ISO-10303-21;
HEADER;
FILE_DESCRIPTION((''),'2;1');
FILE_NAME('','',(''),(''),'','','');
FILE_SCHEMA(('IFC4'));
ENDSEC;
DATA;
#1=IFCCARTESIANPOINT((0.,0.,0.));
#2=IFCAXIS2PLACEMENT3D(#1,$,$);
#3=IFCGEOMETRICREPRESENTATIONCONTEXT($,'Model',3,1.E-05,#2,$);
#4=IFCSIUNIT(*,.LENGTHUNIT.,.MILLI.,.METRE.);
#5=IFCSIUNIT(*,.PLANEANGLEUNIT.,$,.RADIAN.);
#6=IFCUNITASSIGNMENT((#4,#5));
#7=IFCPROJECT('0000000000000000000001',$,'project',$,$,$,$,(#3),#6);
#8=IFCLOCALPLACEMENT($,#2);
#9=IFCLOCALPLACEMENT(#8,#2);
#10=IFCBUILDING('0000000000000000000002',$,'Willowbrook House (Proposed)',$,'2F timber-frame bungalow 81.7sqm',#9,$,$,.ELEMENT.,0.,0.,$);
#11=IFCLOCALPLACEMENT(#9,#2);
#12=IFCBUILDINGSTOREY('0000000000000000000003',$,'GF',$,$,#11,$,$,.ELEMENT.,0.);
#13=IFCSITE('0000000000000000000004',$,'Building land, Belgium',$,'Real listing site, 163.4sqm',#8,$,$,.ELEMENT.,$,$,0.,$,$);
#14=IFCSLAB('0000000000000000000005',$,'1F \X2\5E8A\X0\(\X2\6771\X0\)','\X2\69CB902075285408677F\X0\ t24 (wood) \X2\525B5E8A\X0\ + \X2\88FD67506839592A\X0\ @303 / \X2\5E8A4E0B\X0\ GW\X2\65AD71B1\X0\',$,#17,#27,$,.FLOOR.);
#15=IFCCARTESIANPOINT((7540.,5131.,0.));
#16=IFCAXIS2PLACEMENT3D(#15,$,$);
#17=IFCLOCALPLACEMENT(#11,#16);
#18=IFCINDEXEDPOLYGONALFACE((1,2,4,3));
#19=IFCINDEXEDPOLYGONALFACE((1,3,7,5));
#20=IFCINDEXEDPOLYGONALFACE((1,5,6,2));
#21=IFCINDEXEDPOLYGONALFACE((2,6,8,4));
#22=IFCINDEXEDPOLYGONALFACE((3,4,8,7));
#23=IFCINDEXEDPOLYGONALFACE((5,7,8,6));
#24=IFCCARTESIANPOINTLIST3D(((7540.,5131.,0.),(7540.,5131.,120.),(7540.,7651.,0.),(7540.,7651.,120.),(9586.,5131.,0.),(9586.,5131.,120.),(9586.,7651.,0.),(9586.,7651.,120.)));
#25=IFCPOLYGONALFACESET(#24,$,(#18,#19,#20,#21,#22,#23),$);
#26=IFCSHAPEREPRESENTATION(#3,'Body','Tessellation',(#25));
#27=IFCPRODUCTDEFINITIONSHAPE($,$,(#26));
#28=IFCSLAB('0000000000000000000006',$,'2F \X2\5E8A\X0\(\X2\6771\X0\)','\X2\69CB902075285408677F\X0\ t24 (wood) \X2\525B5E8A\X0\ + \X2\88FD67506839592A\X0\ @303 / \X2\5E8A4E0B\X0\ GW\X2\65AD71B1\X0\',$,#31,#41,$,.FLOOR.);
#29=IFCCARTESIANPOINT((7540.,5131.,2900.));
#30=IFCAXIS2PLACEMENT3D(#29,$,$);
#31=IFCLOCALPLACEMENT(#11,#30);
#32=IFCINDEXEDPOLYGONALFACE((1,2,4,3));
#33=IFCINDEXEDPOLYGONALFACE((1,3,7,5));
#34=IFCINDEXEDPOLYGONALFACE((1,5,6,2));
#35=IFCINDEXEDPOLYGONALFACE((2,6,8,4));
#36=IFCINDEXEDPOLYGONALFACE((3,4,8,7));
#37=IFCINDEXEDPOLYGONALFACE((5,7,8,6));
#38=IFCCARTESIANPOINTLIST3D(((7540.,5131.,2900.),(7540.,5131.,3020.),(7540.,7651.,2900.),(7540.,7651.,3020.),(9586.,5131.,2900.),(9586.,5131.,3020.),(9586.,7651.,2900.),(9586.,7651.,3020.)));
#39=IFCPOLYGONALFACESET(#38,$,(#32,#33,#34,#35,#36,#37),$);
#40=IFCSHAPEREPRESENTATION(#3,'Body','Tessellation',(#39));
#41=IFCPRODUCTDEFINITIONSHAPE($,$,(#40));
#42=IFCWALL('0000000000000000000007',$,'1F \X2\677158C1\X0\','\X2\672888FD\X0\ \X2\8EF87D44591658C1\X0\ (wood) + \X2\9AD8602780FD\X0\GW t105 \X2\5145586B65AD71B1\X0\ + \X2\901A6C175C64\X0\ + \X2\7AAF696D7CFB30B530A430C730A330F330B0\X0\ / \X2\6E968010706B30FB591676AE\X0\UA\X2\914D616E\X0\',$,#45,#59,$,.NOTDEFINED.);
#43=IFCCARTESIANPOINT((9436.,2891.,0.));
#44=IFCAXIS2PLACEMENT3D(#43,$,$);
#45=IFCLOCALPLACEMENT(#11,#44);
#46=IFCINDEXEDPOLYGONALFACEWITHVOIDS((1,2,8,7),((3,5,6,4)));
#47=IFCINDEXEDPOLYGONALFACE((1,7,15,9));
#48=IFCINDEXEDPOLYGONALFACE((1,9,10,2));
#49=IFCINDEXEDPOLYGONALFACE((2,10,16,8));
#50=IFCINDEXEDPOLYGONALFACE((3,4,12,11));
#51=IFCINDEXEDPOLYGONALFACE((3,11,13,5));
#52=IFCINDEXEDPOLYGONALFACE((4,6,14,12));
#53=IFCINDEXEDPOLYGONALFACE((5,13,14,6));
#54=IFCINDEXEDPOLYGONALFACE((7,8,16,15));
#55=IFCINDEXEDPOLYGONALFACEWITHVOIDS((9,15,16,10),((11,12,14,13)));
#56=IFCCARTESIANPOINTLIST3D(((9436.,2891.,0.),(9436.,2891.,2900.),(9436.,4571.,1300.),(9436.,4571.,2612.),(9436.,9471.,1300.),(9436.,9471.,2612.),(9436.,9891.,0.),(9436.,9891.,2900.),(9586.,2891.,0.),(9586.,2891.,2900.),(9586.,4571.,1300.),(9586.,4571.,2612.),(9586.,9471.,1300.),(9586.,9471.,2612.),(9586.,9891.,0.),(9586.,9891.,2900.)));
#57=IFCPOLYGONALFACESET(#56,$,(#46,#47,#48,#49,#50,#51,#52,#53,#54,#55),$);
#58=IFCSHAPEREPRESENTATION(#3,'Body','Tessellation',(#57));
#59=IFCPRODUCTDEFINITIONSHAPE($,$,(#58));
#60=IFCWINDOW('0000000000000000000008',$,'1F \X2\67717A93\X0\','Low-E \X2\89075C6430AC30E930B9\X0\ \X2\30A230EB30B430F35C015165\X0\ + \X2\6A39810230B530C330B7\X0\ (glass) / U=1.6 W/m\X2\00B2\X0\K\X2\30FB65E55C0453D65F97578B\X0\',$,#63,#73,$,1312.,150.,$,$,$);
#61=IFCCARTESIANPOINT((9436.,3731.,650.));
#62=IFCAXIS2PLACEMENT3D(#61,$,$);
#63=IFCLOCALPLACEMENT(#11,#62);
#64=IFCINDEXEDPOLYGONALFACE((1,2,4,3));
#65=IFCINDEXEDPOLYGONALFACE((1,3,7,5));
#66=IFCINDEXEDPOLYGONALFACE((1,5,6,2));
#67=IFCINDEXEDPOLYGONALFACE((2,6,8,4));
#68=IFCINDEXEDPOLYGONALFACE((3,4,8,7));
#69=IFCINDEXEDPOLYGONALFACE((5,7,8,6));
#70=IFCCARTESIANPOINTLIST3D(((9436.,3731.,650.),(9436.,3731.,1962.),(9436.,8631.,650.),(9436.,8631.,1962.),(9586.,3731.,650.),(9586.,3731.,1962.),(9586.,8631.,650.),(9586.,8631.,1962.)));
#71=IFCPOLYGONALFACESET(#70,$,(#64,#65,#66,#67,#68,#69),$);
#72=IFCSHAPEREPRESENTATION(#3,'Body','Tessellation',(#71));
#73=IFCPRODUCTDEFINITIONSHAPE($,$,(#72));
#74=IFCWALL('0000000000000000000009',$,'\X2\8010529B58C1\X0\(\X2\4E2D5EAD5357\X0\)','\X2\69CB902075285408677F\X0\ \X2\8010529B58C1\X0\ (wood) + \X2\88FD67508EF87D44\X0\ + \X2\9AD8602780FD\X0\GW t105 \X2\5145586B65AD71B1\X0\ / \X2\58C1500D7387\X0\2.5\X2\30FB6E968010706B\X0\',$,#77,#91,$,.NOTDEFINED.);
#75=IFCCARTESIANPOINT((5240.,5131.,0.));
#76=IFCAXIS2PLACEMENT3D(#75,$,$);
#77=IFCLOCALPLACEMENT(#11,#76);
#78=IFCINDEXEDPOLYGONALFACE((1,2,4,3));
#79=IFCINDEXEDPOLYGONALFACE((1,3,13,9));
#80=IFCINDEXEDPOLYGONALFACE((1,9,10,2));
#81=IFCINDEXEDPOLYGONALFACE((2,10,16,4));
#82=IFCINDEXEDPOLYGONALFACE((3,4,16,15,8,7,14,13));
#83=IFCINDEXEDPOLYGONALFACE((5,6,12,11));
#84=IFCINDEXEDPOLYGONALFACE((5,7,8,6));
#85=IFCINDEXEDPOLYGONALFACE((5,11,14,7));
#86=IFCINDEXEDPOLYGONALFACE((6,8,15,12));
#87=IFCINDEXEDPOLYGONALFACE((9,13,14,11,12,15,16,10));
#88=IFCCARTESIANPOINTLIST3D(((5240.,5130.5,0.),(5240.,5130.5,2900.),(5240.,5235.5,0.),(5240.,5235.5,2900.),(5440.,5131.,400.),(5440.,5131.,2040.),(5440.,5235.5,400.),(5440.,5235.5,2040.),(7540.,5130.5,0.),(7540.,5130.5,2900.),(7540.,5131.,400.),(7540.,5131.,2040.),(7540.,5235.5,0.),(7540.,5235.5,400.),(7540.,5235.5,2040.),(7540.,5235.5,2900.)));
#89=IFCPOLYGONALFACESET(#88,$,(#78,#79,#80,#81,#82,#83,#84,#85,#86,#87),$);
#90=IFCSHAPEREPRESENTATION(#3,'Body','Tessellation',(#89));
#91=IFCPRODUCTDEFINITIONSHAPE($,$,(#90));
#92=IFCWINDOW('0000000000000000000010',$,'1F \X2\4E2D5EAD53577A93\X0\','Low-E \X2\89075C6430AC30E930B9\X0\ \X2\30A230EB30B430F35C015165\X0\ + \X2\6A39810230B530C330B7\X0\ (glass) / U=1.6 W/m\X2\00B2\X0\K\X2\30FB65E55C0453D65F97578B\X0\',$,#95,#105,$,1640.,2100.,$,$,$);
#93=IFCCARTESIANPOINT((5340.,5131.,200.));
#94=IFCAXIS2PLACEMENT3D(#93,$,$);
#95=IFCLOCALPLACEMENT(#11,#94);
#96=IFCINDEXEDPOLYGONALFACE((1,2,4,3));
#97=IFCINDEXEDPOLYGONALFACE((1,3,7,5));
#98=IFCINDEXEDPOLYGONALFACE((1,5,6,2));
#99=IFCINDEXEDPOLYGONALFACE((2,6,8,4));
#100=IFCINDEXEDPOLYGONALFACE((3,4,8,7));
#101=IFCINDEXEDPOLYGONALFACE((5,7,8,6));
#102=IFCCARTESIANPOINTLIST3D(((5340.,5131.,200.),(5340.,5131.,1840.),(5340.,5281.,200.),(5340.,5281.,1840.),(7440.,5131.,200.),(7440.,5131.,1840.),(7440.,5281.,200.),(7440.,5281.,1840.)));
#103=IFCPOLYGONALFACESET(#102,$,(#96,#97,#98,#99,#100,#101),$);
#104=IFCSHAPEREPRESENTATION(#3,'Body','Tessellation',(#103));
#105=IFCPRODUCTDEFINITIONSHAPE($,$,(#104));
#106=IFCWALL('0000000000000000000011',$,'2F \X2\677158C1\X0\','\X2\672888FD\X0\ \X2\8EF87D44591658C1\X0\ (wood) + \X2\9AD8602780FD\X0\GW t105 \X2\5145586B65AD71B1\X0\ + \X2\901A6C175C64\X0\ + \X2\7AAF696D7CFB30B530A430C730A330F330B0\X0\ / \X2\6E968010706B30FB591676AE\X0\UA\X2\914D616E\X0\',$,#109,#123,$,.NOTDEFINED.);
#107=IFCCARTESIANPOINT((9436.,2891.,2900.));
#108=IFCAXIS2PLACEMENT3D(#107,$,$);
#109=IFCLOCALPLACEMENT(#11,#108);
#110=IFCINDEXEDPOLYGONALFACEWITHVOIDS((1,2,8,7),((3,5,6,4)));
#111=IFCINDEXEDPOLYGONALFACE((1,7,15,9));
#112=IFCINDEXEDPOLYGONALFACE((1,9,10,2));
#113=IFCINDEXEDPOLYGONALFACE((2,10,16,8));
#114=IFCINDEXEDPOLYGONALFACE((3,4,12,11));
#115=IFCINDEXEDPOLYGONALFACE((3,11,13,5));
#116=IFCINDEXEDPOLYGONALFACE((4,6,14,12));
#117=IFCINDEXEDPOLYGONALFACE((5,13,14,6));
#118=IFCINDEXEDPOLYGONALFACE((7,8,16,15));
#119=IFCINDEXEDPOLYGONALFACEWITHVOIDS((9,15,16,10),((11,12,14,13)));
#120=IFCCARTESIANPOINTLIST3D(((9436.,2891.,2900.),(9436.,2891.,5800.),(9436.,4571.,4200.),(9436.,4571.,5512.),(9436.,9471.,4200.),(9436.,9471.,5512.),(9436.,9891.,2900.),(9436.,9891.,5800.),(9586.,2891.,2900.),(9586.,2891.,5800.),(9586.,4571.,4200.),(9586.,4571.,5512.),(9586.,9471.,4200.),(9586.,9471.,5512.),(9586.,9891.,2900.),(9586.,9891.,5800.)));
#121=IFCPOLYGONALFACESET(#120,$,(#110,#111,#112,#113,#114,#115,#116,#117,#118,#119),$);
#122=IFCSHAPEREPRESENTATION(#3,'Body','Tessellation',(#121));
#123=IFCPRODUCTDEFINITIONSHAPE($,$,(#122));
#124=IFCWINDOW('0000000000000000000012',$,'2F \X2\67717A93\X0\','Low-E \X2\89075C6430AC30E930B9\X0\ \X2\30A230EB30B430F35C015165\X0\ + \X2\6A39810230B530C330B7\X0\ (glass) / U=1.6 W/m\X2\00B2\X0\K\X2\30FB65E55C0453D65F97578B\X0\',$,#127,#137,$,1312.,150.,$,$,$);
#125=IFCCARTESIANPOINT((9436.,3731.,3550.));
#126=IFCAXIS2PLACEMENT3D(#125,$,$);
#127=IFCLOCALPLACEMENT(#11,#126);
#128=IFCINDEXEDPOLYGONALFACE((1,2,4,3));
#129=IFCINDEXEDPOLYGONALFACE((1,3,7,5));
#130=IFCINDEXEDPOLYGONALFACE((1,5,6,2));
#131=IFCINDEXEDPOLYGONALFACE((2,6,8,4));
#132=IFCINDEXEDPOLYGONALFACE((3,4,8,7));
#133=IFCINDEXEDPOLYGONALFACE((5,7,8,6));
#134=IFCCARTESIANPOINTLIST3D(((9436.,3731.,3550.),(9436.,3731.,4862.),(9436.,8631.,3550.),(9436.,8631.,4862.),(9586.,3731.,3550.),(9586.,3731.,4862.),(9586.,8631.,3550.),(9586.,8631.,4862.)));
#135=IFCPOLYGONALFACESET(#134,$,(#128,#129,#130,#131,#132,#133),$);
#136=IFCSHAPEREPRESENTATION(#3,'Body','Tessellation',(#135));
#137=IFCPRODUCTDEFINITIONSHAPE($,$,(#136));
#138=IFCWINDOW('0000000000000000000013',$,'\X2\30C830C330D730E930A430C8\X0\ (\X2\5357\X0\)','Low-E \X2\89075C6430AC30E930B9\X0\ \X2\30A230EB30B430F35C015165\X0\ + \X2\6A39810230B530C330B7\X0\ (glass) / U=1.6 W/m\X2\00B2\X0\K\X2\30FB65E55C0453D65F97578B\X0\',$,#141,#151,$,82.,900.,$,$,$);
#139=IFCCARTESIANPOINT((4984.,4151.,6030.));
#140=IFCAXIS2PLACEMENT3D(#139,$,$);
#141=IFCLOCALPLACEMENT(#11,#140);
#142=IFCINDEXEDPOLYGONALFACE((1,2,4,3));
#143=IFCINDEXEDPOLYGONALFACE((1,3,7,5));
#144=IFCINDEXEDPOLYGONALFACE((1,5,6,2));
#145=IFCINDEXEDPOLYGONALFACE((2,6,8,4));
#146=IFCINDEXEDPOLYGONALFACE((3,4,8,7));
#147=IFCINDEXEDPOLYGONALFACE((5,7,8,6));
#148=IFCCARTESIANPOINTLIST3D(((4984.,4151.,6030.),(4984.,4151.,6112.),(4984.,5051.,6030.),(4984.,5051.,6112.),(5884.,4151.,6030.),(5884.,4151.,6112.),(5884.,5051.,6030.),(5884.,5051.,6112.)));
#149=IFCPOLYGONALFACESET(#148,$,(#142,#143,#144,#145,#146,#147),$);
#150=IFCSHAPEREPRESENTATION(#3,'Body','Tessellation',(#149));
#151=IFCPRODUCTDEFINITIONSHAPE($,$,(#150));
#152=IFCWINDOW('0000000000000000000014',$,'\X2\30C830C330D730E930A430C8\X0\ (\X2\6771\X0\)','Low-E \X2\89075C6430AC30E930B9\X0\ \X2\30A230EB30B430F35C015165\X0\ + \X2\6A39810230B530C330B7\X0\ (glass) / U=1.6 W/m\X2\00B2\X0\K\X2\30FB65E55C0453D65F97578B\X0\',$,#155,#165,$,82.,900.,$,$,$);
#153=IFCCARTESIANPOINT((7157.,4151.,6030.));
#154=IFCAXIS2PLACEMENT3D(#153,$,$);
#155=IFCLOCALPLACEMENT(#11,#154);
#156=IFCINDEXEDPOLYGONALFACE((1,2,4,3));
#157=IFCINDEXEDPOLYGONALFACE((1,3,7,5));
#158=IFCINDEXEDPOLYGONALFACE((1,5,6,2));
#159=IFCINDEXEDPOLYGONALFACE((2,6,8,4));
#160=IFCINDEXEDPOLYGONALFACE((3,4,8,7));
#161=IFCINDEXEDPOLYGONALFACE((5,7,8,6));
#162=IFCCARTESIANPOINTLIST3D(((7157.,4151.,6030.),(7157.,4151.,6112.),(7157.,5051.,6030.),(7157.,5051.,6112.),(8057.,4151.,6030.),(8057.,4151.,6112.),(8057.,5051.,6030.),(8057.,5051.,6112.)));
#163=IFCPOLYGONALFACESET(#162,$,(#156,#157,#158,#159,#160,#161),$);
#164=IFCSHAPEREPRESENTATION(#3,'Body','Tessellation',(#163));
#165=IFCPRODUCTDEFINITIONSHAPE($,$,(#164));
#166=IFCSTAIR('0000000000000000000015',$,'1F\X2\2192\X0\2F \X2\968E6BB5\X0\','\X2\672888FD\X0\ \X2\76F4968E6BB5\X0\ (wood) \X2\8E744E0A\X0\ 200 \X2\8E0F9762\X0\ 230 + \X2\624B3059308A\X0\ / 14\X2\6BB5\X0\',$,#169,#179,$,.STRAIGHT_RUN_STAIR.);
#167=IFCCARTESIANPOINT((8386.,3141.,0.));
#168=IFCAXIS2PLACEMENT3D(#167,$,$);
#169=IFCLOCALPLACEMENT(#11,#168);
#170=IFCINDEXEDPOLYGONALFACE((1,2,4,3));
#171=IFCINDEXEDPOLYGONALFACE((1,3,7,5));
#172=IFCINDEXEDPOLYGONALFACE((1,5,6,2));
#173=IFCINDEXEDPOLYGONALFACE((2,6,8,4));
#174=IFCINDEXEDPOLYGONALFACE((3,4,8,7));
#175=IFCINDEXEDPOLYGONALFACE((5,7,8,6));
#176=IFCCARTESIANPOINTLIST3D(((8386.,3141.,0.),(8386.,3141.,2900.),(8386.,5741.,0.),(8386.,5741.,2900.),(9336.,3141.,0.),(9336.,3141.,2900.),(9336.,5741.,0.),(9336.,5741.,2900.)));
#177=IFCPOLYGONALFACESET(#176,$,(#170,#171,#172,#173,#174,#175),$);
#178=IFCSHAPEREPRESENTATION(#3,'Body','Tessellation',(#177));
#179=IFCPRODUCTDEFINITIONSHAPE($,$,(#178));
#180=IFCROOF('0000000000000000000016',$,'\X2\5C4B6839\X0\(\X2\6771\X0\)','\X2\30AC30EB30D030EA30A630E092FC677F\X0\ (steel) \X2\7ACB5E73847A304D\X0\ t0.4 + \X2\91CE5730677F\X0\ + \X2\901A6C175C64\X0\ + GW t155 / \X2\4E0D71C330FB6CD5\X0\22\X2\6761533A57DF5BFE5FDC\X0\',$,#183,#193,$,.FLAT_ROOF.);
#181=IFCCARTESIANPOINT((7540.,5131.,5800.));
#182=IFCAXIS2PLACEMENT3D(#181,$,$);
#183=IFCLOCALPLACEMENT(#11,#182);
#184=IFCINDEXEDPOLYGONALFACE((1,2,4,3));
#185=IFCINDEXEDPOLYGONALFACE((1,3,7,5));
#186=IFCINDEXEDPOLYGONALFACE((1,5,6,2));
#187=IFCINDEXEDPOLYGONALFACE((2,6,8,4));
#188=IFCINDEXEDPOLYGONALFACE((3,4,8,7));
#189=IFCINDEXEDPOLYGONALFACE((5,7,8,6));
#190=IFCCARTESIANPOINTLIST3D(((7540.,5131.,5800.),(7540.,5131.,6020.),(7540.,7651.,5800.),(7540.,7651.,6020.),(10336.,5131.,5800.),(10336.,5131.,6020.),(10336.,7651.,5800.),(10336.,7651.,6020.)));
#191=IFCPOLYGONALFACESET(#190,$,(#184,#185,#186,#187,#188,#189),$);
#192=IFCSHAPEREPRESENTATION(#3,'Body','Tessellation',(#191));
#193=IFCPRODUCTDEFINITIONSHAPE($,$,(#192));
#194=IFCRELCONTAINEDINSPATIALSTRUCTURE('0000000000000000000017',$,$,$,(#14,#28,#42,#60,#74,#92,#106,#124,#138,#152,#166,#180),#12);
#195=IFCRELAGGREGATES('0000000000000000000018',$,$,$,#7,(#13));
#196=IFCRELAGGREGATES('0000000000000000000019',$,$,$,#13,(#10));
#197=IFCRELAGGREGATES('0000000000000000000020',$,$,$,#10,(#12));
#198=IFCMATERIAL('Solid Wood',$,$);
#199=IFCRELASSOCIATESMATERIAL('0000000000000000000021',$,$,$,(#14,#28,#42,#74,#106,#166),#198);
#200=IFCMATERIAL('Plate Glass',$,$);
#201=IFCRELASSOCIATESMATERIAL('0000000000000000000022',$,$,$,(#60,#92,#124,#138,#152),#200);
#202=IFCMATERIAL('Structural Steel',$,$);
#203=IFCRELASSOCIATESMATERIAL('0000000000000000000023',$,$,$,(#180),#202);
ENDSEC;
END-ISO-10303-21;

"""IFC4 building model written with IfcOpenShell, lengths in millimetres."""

from ifc_helpers import new_model, si_unit, frame, frame_2d, origin, place, context, project, spatial, rectangle, extrude, material, element, fill, save


model = new_model("IFC4")

# Units and contexts
model_context = context("Model", 3, precision=1e-05, world=origin())
ifc_project = project(units=[si_unit("LENGTHUNIT", "METRE", prefix="MILLI"), si_unit("PLANEANGLEUNIT", "RADIAN")], contexts=[model_context])

# Site, building, storey
site_placement = place(None, origin())
site = spatial("IfcSite", under=ifc_project, at=site_placement, Name="Building land, Belgium", ObjectType="Real listing site, 163.4sqm", CompositionType="ELEMENT", RefElevation=0.0)
building_placement = place(site_placement, origin())
building = spatial("IfcBuilding", under=site, at=building_placement, Name="Willowbrook House (Proposed)", ObjectType="2F timber-frame bungalow 81.7sqm", CompositionType="ELEMENT", ElevationOfRefHeight=0.0, ElevationOfTerrain=0.0)
storey_placement = place(building_placement, origin())
storey = spatial("IfcBuildingStorey", under=building, at=storey_placement, Name="GF", CompositionType="ELEMENT", Elevation=0.0)

# Slabs
ifc_material_1 = material(Name="Solid Wood")
slab_1_placement = place(storey_placement, frame((7540.0, 5131.0, 0.0)))
element("IfcSlab", 1, at=slab_1_placement, inside=storey, material=ifc_material_1, Name="1F 床(東)", Description="構造用合板 t24 (wood) 剛床 + 製材根太 @303 / 床下 GW断熱", PredefinedType="FLOOR", context=model_context, shape_type="SweptSolid", body=[
    extrude(rectangle(XDim=2046.0, YDim=2520.0, at=frame_2d((1023.0, 1260.0))), frame((7540.0, 5131.0, 0.0)), (0.0, 0.0, 1.0), 120.0),
])
slab_2_placement = place(storey_placement, frame((7540.0, 5131.0, 2900.0)))
element("IfcSlab", 2, at=slab_2_placement, inside=storey, material=ifc_material_1, Name="2F 床(東)", Description="構造用合板 t24 (wood) 剛床 + 製材根太 @303 / 床下 GW断熱", PredefinedType="FLOOR", context=model_context, shape_type="SweptSolid", body=[
    extrude(rectangle(XDim=2046.0, YDim=2520.0, at=frame_2d((1023.0, 1260.0))), frame((7540.0, 5131.0, 2900.0)), (0.0, 0.0, 1.0), 120.0),
])

# Walls, openings, windows
wall_1_placement = place(storey_placement, frame((9436.0, 2891.0, 0.0)))
wall_1 = element("IfcWall", 3, at=wall_1_placement, inside=storey, material=ifc_material_1, Name="1F 東壁", Description="木製 軸組外壁 (wood) + 高性能GW t105 充填断熱 + 通気層 + 窯業系サイディング / 準耐火・外皮UA配慮", PredefinedType="NOTDEFINED", context=model_context, shape_type="SweptSolid", body=[
    extrude(rectangle(XDim=150.0, YDim=7000.0, at=frame_2d((75.0, 3500.0))), frame((9436.0, 2891.0, 0.0)), (0.0, 0.0, 1.0), 2900.0),
])
opening_1_placement = place(storey_placement, frame((9436.0, 3731.0, 650.0)))
opening_1 = element("IfcOpeningElement", 4, at=opening_1_placement, cuts=wall_1, PredefinedType="NOTDEFINED", context=model_context, shape_type="SweptSolid", body=[
    extrude(rectangle(XDim=150.0, YDim=4900.0, at=frame_2d((75.0, 2450.0))), frame((9436.0, 3731.0, 650.0)), (0.0, 0.0, 1.0), 1312.0),
])
ifc_material_2 = material(Name="Plate Glass")
window_1_placement = place(storey_placement, frame((9436.0, 3731.0, 650.0)))
window_1 = element("IfcWindow", 5, at=window_1_placement, inside=storey, material=ifc_material_2, Name="1F 東窓", Description="Low-E 複層ガラス アルゴン封入 + 樹脂サッシ (glass) / U=1.6 W/m²K・日射取得型", OverallHeight=1312.0, OverallWidth=150.0, context=model_context, shape_type="SweptSolid", body=[
    extrude(rectangle(XDim=150.0, YDim=4900.0, at=frame_2d((75.0, 2450.0))), frame((9436.0, 3731.0, 650.0)), (0.0, 0.0, 1.0), 1312.0),
])
fill(opening_1, window_1)
wall_2_placement = place(storey_placement, frame((5240.0, 5131.0, 0.0)))
wall_2 = element("IfcWall", 6, at=wall_2_placement, inside=storey, material=ifc_material_1, Name="耐力壁(中庭南)", Description="構造用合板 耐力壁 (wood) + 製材軸組 + 高性能GW t105 充填断熱 / 壁倍率2.5・準耐火", PredefinedType="NOTDEFINED", context=model_context, shape_type="SweptSolid", body=[
    extrude(rectangle(XDim=2300.0, YDim=105.0, at=frame_2d((1150.0, 52.0))), frame((5240.0, 5131.0, 0.0)), (0.0, 0.0, 1.0), 2900.0),
])
opening_2_placement = place(storey_placement, frame((5340.0, 5131.0, 200.0)))
opening_2 = element("IfcOpeningElement", 7, at=opening_2_placement, cuts=wall_2, PredefinedType="NOTDEFINED", context=model_context, shape_type="SweptSolid", body=[
    extrude(rectangle(XDim=2100.0, YDim=150.0, at=frame_2d((1050.0, 75.0))), frame((5340.0, 5131.0, 200.0)), (0.0, 0.0, 1.0), 1640.0),
])
window_2_placement = place(storey_placement, frame((5340.0, 5131.0, 200.0)))
window_2 = element("IfcWindow", 8, at=window_2_placement, inside=storey, material=ifc_material_2, Name="1F 中庭南窓", Description="Low-E 複層ガラス アルゴン封入 + 樹脂サッシ (glass) / U=1.6 W/m²K・日射取得型", OverallHeight=1640.0, OverallWidth=2100.0, context=model_context, shape_type="SweptSolid", body=[
    extrude(rectangle(XDim=2100.0, YDim=150.0, at=frame_2d((1050.0, 75.0))), frame((5340.0, 5131.0, 200.0)), (0.0, 0.0, 1.0), 1640.0),
])
fill(opening_2, window_2)

# Wall, opening, window
wall_3_placement = place(storey_placement, frame((9436.0, 2891.0, 2900.0)))
wall_3 = element("IfcWall", 9, at=wall_3_placement, inside=storey, material=ifc_material_1, Name="2F 東壁", Description="木製 軸組外壁 (wood) + 高性能GW t105 充填断熱 + 通気層 + 窯業系サイディング / 準耐火・外皮UA配慮", PredefinedType="NOTDEFINED", context=model_context, shape_type="SweptSolid", body=[
    extrude(rectangle(XDim=150.0, YDim=7000.0, at=frame_2d((75.0, 3500.0))), frame((9436.0, 2891.0, 2900.0)), (0.0, 0.0, 1.0), 2900.0),
])
opening_3_placement = place(storey_placement, frame((9436.0, 3731.0, 3550.0)))
opening_3 = element("IfcOpeningElement", 10, at=opening_3_placement, cuts=wall_3, PredefinedType="NOTDEFINED", context=model_context, shape_type="SweptSolid", body=[
    extrude(rectangle(XDim=150.0, YDim=4900.0, at=frame_2d((75.0, 2450.0))), frame((9436.0, 3731.0, 3550.0)), (0.0, 0.0, 1.0), 1312.0),
])
window_3_placement = place(storey_placement, frame((9436.0, 3731.0, 3550.0)))
window_3 = element("IfcWindow", 11, at=window_3_placement, inside=storey, material=ifc_material_2, Name="2F 東窓", Description="Low-E 複層ガラス アルゴン封入 + 樹脂サッシ (glass) / U=1.6 W/m²K・日射取得型", OverallHeight=1312.0, OverallWidth=150.0, context=model_context, shape_type="SweptSolid", body=[
    extrude(rectangle(XDim=150.0, YDim=4900.0, at=frame_2d((75.0, 2450.0))), frame((9436.0, 3731.0, 3550.0)), (0.0, 0.0, 1.0), 1312.0),
])
fill(opening_3, window_3)

# Windows
window_4_placement = place(storey_placement, frame((4984.0, 4151.0, 6030.0)))
element("IfcWindow", 12, at=window_4_placement, inside=storey, material=ifc_material_2, Name="トップライト (南)", Description="Low-E 複層ガラス アルゴン封入 + 樹脂サッシ (glass) / U=1.6 W/m²K・日射取得型", OverallHeight=82.0, OverallWidth=900.0, context=model_context, shape_type="SweptSolid", body=[
    extrude(rectangle(XDim=900.0, YDim=900.0, at=frame_2d((450.0, 450.0))), frame((4984.0, 4151.0, 6030.0)), (0.0, 0.0, 1.0), 82.0),
])
window_5_placement = place(storey_placement, frame((7157.0, 4151.0, 6030.0)))
element("IfcWindow", 13, at=window_5_placement, inside=storey, material=ifc_material_2, Name="トップライト (東)", Description="Low-E 複層ガラス アルゴン封入 + 樹脂サッシ (glass) / U=1.6 W/m²K・日射取得型", OverallHeight=82.0, OverallWidth=900.0, context=model_context, shape_type="SweptSolid", body=[
    extrude(rectangle(XDim=900.0, YDim=900.0, at=frame_2d((450.0, 450.0))), frame((7157.0, 4151.0, 6030.0)), (0.0, 0.0, 1.0), 82.0),
])

# Stair
stair_placement = place(storey_placement, frame((8386.0, 3141.0, 0.0)))
element("IfcStair", 14, at=stair_placement, inside=storey, material=ifc_material_1, Name="1F→2F 階段", Description="木製 直階段 (wood) 蹴上 200 踏面 230 + 手すり / 14段", PredefinedType="STRAIGHT_RUN_STAIR", context=model_context, shape_type="SweptSolid", body=[
    extrude(rectangle(XDim=950.0, YDim=2600.0, at=frame_2d((475.0, 1300.0))), frame((8386.0, 3141.0, 0.0)), (0.0, 0.0, 1.0), 2900.0),
])

# Roof
ifc_material_3 = material(Name="Structural Steel")
roof_placement = place(storey_placement, frame((7540.0, 5131.0, 5800.0)))
element("IfcRoof", 15, at=roof_placement, inside=storey, material=ifc_material_3, Name="屋根(東)", Description="ガルバリウム鋼板 (steel) 立平葺き t0.4 + 野地板 + 通気層 + GW t155 / 不燃・法22条区域対応", PredefinedType="FLAT_ROOF", context=model_context, shape_type="SweptSolid", body=[
    extrude(rectangle(XDim=2796.0, YDim=2520.0, at=frame_2d((1398.0, 1260.0))), frame((7540.0, 5131.0, 5800.0)), (0.0, 0.0, 1.0), 220.0),
])

save(model, "model.ifc")
